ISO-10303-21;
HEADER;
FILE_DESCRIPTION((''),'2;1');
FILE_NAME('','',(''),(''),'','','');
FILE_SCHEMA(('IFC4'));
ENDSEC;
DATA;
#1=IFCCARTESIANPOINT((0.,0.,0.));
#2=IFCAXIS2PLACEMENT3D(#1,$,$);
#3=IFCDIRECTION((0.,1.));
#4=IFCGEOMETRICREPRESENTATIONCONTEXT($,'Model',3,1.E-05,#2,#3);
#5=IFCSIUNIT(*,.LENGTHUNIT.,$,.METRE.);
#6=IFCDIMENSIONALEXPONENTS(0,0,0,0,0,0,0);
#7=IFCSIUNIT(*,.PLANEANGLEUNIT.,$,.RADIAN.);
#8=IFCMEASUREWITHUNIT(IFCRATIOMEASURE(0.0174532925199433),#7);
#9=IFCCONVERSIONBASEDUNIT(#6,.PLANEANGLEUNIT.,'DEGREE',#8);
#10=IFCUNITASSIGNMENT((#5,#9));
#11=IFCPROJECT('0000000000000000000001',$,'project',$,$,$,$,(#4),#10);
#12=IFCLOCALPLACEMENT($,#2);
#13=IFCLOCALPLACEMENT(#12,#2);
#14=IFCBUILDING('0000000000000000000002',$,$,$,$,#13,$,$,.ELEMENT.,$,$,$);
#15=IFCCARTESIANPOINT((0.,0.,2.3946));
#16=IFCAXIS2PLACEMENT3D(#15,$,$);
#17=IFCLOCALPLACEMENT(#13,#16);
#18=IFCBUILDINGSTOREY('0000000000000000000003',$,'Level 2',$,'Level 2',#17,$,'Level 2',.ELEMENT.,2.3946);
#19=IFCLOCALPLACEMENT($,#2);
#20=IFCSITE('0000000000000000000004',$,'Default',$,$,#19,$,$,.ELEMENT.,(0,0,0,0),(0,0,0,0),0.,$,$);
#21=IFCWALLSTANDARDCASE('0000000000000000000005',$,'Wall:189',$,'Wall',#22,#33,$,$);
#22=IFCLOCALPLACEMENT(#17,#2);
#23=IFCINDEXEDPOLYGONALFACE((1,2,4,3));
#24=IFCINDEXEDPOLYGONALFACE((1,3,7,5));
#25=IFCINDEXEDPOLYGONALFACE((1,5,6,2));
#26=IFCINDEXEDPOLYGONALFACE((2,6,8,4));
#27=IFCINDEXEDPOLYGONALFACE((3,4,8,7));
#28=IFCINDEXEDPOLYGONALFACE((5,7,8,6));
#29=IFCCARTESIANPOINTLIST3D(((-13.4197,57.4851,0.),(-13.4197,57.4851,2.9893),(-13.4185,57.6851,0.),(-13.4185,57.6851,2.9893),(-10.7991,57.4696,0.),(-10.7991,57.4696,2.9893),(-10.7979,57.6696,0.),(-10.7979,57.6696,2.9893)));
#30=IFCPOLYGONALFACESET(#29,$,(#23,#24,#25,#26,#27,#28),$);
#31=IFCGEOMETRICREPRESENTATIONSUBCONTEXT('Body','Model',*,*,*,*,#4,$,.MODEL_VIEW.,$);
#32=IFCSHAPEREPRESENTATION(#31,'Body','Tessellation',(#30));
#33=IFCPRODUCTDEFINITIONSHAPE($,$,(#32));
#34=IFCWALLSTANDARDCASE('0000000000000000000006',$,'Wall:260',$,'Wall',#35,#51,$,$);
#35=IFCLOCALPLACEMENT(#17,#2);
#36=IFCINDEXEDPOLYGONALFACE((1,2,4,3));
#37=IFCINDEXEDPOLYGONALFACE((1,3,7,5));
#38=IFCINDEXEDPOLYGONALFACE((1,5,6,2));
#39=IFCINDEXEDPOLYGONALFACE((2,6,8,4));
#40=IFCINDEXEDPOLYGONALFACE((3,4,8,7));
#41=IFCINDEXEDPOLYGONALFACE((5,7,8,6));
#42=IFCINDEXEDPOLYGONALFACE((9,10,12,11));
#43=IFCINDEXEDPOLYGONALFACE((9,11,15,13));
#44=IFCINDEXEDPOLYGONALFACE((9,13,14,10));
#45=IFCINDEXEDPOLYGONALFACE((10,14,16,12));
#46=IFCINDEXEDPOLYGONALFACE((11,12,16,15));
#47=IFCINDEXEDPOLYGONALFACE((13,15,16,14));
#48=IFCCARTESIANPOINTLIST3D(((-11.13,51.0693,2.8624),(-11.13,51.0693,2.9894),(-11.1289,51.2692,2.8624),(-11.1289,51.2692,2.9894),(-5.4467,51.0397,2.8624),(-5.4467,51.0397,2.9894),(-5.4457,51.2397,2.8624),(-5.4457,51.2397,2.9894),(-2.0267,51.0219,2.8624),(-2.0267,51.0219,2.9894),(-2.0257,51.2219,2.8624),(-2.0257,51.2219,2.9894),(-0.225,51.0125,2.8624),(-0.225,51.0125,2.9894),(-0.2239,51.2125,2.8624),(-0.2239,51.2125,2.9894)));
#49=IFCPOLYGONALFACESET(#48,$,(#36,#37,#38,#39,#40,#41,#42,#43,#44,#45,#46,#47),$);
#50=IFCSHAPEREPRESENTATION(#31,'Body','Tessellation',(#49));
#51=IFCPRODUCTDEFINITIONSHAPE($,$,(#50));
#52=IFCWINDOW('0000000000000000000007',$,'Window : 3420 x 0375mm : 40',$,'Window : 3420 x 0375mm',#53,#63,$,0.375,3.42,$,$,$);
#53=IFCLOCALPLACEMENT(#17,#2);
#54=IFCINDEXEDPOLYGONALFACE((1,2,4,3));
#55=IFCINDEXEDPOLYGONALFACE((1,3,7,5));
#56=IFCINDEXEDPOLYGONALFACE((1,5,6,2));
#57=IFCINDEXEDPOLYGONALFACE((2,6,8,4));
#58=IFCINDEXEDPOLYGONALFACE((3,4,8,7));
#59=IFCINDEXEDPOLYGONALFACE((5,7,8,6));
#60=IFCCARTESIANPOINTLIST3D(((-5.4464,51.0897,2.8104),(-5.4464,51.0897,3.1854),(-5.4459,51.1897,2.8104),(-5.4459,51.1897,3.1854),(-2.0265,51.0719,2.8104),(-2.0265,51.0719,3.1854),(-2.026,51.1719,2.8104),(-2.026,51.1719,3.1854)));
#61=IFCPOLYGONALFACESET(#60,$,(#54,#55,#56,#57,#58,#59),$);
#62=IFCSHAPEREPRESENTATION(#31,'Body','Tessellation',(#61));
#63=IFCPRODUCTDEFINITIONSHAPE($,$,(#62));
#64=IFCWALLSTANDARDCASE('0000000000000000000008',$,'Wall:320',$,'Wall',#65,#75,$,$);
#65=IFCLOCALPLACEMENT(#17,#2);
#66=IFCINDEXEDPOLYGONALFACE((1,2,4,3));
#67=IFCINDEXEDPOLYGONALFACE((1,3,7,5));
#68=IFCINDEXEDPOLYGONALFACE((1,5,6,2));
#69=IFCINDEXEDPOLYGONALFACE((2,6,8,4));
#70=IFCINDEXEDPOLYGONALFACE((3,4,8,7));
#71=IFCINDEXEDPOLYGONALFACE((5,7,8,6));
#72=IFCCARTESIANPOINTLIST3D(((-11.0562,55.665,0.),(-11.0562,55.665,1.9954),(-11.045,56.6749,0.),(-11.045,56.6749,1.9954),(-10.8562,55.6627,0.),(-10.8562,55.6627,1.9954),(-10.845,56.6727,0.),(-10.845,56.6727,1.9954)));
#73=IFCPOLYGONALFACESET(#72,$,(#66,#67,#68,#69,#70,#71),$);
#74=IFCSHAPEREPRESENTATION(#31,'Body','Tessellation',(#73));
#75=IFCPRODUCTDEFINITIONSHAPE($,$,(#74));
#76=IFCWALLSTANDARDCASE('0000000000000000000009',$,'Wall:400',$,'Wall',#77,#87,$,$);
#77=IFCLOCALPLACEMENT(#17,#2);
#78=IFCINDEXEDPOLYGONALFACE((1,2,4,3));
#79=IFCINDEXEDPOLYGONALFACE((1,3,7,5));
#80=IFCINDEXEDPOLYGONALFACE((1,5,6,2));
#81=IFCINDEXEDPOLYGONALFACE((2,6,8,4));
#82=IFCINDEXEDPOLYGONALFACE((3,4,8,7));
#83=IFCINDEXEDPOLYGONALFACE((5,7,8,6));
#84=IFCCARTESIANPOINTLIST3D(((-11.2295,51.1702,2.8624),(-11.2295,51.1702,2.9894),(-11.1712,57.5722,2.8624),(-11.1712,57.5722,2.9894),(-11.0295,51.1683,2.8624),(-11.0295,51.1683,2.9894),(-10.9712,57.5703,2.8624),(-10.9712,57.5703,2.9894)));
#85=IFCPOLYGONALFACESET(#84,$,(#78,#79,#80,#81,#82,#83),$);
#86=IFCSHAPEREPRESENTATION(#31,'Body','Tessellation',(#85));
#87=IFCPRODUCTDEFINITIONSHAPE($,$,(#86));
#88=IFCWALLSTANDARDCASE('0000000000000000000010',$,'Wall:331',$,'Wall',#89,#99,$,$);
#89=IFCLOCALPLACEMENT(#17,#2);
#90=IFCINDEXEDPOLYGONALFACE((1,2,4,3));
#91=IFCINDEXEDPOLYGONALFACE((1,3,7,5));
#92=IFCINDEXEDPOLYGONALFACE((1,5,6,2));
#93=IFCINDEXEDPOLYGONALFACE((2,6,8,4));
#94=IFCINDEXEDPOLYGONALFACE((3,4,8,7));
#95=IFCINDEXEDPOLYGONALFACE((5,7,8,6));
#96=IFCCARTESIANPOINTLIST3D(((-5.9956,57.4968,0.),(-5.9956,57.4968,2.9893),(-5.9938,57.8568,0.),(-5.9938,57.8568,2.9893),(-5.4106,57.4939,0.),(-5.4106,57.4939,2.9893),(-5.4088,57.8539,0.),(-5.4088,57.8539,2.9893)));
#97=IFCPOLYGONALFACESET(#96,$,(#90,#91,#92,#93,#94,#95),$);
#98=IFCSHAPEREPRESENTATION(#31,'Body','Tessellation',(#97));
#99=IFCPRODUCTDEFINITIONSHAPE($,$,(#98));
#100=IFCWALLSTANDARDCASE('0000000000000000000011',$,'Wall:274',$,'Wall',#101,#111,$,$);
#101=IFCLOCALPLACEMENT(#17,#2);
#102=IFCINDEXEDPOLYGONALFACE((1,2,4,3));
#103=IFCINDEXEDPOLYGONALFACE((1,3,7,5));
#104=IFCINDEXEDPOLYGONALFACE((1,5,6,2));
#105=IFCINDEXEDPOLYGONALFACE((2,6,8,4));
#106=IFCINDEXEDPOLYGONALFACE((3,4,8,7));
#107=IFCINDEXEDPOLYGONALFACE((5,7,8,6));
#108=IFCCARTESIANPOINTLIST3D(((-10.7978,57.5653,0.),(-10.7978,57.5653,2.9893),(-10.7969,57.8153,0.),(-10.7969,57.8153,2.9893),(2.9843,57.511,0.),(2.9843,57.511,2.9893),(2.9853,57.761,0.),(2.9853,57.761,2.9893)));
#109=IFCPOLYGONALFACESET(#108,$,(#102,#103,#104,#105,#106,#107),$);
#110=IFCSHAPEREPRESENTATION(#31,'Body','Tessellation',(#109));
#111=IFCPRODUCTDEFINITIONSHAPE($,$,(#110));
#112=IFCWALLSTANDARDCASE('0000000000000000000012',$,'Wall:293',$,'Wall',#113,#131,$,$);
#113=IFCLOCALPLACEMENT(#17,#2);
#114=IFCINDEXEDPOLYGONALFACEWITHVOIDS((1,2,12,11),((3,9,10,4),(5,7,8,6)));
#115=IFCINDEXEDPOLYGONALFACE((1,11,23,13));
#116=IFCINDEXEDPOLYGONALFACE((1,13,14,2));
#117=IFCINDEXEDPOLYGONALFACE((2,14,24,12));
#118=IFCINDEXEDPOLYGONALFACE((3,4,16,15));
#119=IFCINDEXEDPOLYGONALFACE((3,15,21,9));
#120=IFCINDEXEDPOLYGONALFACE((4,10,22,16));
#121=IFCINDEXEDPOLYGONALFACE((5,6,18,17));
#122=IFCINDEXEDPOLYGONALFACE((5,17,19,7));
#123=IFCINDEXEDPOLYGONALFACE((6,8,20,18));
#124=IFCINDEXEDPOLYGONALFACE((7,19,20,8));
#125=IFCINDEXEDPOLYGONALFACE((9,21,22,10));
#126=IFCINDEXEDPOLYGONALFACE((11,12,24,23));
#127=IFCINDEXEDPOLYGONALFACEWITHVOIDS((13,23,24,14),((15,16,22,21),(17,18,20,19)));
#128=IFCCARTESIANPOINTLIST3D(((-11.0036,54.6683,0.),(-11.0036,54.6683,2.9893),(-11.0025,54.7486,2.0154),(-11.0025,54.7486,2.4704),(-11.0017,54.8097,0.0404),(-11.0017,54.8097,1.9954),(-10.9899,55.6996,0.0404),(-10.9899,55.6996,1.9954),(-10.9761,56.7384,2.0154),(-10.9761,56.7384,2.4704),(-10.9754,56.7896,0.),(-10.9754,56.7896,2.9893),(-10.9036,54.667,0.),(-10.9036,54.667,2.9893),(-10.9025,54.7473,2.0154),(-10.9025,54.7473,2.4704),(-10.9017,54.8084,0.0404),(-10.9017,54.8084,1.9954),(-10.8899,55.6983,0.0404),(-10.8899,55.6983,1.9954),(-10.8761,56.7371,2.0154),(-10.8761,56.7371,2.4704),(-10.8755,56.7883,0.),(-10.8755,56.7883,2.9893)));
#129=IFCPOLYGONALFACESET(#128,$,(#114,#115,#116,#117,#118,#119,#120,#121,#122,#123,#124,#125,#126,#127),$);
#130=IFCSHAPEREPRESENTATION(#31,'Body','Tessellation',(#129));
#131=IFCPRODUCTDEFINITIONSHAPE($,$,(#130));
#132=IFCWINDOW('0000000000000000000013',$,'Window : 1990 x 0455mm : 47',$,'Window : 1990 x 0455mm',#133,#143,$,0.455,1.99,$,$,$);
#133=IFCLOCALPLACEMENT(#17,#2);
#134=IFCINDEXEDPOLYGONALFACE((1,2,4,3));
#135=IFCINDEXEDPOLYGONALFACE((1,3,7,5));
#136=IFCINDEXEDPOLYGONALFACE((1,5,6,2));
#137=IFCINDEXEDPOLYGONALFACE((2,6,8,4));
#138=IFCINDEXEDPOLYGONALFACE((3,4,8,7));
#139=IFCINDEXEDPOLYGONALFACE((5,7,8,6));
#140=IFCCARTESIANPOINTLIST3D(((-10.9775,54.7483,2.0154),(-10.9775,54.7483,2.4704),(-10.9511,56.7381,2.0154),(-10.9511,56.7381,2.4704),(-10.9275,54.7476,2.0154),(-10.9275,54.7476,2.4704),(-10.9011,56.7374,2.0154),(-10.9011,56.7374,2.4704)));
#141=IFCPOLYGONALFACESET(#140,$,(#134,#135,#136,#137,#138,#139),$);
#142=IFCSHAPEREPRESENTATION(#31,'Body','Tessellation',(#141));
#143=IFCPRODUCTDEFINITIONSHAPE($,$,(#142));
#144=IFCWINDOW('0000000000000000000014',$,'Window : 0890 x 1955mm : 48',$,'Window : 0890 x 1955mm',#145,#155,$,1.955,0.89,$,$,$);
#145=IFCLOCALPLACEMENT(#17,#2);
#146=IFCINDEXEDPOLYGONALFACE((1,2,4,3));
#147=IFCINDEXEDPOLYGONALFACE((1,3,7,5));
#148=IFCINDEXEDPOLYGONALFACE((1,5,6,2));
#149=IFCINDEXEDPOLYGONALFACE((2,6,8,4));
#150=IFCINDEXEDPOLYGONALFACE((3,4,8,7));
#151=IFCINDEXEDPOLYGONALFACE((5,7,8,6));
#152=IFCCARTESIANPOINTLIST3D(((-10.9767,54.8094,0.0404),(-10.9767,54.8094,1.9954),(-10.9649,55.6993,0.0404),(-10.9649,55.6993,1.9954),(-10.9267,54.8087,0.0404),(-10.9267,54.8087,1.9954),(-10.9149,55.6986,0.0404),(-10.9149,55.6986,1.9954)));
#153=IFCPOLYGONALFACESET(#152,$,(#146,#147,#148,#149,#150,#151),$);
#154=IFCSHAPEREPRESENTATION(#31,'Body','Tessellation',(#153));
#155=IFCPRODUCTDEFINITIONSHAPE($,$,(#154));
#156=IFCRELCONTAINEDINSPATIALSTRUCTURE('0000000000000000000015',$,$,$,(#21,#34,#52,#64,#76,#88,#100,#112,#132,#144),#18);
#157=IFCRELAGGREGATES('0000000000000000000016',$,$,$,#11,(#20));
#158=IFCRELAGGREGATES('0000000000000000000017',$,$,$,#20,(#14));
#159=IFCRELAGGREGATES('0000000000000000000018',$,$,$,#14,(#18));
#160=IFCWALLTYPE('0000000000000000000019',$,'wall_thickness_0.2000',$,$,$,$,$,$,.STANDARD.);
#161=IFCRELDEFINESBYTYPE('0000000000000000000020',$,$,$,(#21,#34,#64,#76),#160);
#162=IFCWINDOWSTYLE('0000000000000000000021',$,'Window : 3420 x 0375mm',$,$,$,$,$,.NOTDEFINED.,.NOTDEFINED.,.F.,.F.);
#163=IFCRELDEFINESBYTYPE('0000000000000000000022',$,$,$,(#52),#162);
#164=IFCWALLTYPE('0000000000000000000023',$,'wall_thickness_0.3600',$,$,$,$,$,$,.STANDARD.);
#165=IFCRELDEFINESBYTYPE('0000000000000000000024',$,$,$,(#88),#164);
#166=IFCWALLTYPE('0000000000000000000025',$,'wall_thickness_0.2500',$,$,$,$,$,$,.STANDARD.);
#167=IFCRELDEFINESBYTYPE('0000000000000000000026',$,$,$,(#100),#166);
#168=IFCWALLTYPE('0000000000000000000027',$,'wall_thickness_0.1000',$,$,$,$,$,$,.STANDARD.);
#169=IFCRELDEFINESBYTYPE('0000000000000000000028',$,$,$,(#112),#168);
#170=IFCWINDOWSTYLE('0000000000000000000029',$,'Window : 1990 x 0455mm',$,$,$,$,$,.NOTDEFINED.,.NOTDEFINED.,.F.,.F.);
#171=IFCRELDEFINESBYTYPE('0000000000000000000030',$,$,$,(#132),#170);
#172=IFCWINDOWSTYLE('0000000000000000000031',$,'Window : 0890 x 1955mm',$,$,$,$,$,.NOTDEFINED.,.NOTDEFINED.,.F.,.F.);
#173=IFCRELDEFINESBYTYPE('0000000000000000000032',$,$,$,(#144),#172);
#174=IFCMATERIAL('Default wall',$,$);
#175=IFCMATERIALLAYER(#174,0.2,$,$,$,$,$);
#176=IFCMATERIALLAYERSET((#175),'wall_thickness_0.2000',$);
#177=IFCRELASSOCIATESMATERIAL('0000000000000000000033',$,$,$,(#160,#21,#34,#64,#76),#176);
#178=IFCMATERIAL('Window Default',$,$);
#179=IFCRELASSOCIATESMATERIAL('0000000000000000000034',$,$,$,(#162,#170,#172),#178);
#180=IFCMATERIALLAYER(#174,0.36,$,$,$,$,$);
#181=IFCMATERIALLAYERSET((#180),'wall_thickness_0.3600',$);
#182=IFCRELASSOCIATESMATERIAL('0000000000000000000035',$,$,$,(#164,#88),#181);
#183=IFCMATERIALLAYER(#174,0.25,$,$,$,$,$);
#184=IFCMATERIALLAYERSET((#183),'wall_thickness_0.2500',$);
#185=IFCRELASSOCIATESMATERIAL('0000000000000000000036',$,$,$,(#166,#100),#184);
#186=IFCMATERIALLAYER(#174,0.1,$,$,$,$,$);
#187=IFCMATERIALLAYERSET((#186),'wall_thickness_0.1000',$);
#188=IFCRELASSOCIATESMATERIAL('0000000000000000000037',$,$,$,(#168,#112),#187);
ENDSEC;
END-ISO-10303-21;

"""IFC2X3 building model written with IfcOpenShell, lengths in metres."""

from ifc_helpers import new_model, entity, si_unit, converted_unit, direction, frame, frame_2d, origin, origin_2d_with_axis, place, context, subcontext, project, spatial, polyline, rectangle, outline, extrude, source, transform, mapped, material, layer, layer_set, layer_usage, type_object, type_shapes, element, fill, save


model = new_model("IFC2X3")

# Units and contexts
model_context = context("Model", 3, precision=1e-05, world=origin(), true_north=direction((0.0, 1.0)))
body_context = subcontext(model_context, "Body", "Model", "MODEL_VIEW")
ifc_project = project(units=[si_unit("LENGTHUNIT", "METRE"), converted_unit("PLANEANGLEUNIT", "DEGREE", entity("IfcRatioMeasure", 0.0174532925199433), si_unit("PLANEANGLEUNIT", "RADIAN"), dimensions=[0, 0, 0, 0, 0, 0, 0])], contexts=[model_context])

# Site, building, storey
site_placement = place(None, origin())
site = spatial("IfcSite", under=ifc_project, at=site_placement, Name="Default", CompositionType="ELEMENT", RefLatitude=(0, 0, 0, 0), RefLongitude=(0, 0, 0, 0), RefElevation=0.0)
placement_1 = place(None, origin())
building_placement = place(placement_1, origin())
building = spatial("IfcBuilding", under=site, at=building_placement, CompositionType="ELEMENT")
storey_placement = place(building_placement, frame((0.0, 0.0, 2.3946)))
storey = spatial("IfcBuildingStorey", under=building, at=storey_placement, Name="Level 2", ObjectType="Level 2", LongName="Level 2", CompositionType="ELEMENT", Elevation=2.3946)

# Wall
ifc_material_1 = material(Name="Default wall")
ifc_layer_1 = layer(ifc_material_1, 0.2)
ifc_layer_set_1 = layer_set([ifc_layer_1], Name="wall_thickness_0.2000")
ifc_layer_usage_1 = layer_usage(ifc_layer_set_1, "AXIS2", "POSITIVE", -0.1)
wall_type_1 = type_object("IfcWallType", Name="wall_thickness_0.2000", PredefinedType="STANDARD", material=ifc_layer_set_1)
wall_1_placement = place(storey_placement, frame((-10.7985, 57.5696, 0.0), z_axis=(0.0, 0.0, 1.0), x_axis=(-0.999983, 0.005903, 0.0)))
element("IfcWallStandardCase", 1, at=wall_1_placement, inside=storey, type_object=wall_type_1, material=ifc_layer_usage_1, Name="Wall:189", ObjectType="Wall", context=body_context, shape_type="SweptSolid", body=[
    extrude(outline(polyline([(2.6206, -0.1), (2.6206, 0.1), (0.0, 0.1), (0.0, -0.1), (2.6206, -0.1)])), origin(), (0.0, 0.0, 1.0), 2.9893),
])

# Wall, opening, window
placement_2 = place(building_placement, frame((0.0, 0.0, 5.257)))
wall_2_placement = place(placement_2, frame((-11.1295, 51.1693, 0.0), z_axis=(0.0, 0.0, 1.0), x_axis=(0.999986, -0.005206, 0.0)))
wall_2 = element("IfcWallStandardCase", 2, at=wall_2_placement, inside=storey, type_object=wall_type_1, material=ifc_layer_usage_1, Name="Wall:260", ObjectType="Wall", context=body_context, shape_type="SweptSolid", body=[
    extrude(outline(polyline([(10.9052, -0.1), (10.9052, 0.1), (0.0, 0.1), (0.0, -0.1), (10.9052, -0.1)])), origin(), (0.0, 0.0, 1.0), 0.127),
])
opening_1_placement = place(wall_2_placement, frame((5.6834, -0.1, -0.052)))
opening_1 = element("IfcOpeningElement", 3, at=opening_1_placement, cuts=wall_2, ObjectType="Opening", context=body_context, shape_type="SweptSolid", body=[
    extrude(rectangle(XDim=3.42, YDim=0.375, at=frame_2d((0.1875, 1.71), x_axis=(0.0, 1.0))), frame((0.0, 0.0, 0.0), z_axis=(0.0, 1.0, 0.0), x_axis=(0.0, 0.0, 1.0)), (0.0, 0.0, 1.0), 0.2),
])
ifc_material_2 = material(Name="Window Default")
window_style_1 = type_object("IfcWindowStyle", Name="Window : 3420 x 0375mm", ConstructionType="NOTDEFINED", OperationType="NOTDEFINED", ParameterTakesPrecedence=False, Sizeable=False, material=ifc_material_2)
shared_shape_1 = source(origin(), body_context, "Body", "SweptSolid", [
    extrude(rectangle(XDim=0.1, YDim=3.42, at=origin_2d_with_axis()), frame((1.71, 0.1, 0.0), z_axis=(0.0, 0.0, 1.0), x_axis=(0.0, 1.0, 0.0)), (0.0, 0.0, 1.0), 0.375),
])
type_shapes(window_style_1, [shared_shape_1])
window_1_placement = place(opening_1_placement, origin())
window_1 = element("IfcWindow", 4, at=window_1_placement, inside=storey, type_object=window_style_1, Name="Window : 3420 x 0375mm : 40", ObjectType="Window : 3420 x 0375mm", OverallHeight=0.375, OverallWidth=3.42, context=body_context, shape_type="MappedRepresentation", body=[
    mapped(shared_shape_1, transform((0.0, 0.0, 0.0), scale=1.0)),
])
fill(opening_1, window_1)

# Walls
wall_3_placement = place(storey_placement, frame((-10.945, 56.6738, 0.0), z_axis=(0.0, 0.0, 1.0), x_axis=(-0.011159, -0.999938, 0.0)))
element("IfcWallStandardCase", 5, at=wall_3_placement, inside=storey, type_object=wall_type_1, material=ifc_layer_usage_1, Name="Wall:320", ObjectType="Wall", context=body_context, shape_type="SweptSolid", body=[
    extrude(outline(polyline([(1.01, -0.1), (1.01, 0.1), (0.0, 0.1), (0.0, -0.1), (1.01, -0.1)])), origin(), (0.0, 0.0, 1.0), 1.9954),
])
placement_3 = place(building_placement, frame((0.0, 0.0, 5.257)))
wall_4_placement = place(placement_3, frame((-11.0712, 57.5712, 0.0), z_axis=(0.0, 0.0, 1.0), x_axis=(-0.009099, -0.999959, 0.0)))
element("IfcWallStandardCase", 6, at=wall_4_placement, inside=storey, type_object=wall_type_1, material=ifc_layer_usage_1, Name="Wall:400", ObjectType="Wall", context=body_context, shape_type="SweptSolid", body=[
    extrude(outline(polyline([(6.4023, -0.1), (6.4023, 0.1), (0.0, 0.1), (0.0, -0.1), (6.4023, -0.1)])), origin(), (0.0, 0.0, 1.0), 0.127),
])
ifc_layer_2 = layer(ifc_material_1, 0.36)
ifc_layer_set_2 = layer_set([ifc_layer_2], Name="wall_thickness_0.3600")
ifc_layer_usage_2 = layer_usage(ifc_layer_set_2, "AXIS2", "POSITIVE", -0.18)
wall_type_2 = type_object("IfcWallType", Name="wall_thickness_0.3600", PredefinedType="STANDARD", material=ifc_layer_set_2)
wall_5_placement = place(storey_placement, frame((-5.9947, 57.6768, 0.0), z_axis=(0.0, 0.0, 1.0), x_axis=(0.999988, -0.004969, 0.0)))
element("IfcWallStandardCase", 7, at=wall_5_placement, inside=storey, type_object=wall_type_2, material=ifc_layer_usage_2, Name="Wall:331", ObjectType="Wall", context=body_context, shape_type="SweptSolid", body=[
    extrude(outline(polyline([(0.585, -0.18), (0.585, 0.18), (0.0, 0.18), (0.0, -0.18), (0.585, -0.18)])), origin(), (0.0, 0.0, 1.0), 2.9893),
])
ifc_layer_3 = layer(ifc_material_1, 0.25)
ifc_layer_set_3 = layer_set([ifc_layer_3], Name="wall_thickness_0.2500")
ifc_layer_usage_3 = layer_usage(ifc_layer_set_3, "AXIS2", "POSITIVE", -0.125)
wall_type_3 = type_object("IfcWallType", Name="wall_thickness_0.2500", PredefinedType="STANDARD", material=ifc_layer_set_3)
wall_6_placement = place(storey_placement, frame((-10.7973, 57.6903, 0.0), z_axis=(0.0, 0.0, 1.0), x_axis=(0.999992, -0.003941, 0.0)))
element("IfcWallStandardCase", 8, at=wall_6_placement, inside=storey, type_object=wall_type_3, material=ifc_layer_usage_3, Name="Wall:274", ObjectType="Wall", context=body_context, shape_type="SweptSolid", body=[
    extrude(outline(polyline([(13.7823, -0.125), (13.7823, 0.125), (0.0, 0.125), (0.0, -0.125), (13.7823, -0.125)])), origin(), (0.0, 0.0, 1.0), 2.9893),
])

# Wall, openings, windows
ifc_layer_4 = layer(ifc_material_1, 0.1)
ifc_layer_set_4 = layer_set([ifc_layer_4], Name="wall_thickness_0.1000")
ifc_layer_usage_4 = layer_usage(ifc_layer_set_4, "AXIS2", "POSITIVE", -0.05)
wall_type_4 = type_object("IfcWallType", Name="wall_thickness_0.1000", PredefinedType="STANDARD", material=ifc_layer_set_4)
wall_7_placement = place(storey_placement, frame((-10.9255, 56.789, 0.0), z_axis=(0.0, 0.0, 1.0), x_axis=(-0.013268, -0.999912, 0.0)))
wall_7 = element("IfcWallStandardCase", 9, at=wall_7_placement, inside=storey, type_object=wall_type_4, material=ifc_layer_usage_4, Name="Wall:293", ObjectType="Wall", context=body_context, shape_type="SweptSolid", body=[
    extrude(outline(polyline([(2.1215, -0.05), (2.1215, 0.05), (0.0, 0.05), (0.0, -0.05), (2.1215, -0.05)])), origin(), (0.0, 0.0, 1.0), 2.9893),
])
opening_2_placement = place(wall_7_placement, frame((0.0512, -0.05, 2.0154)))
opening_2 = element("IfcOpeningElement", 10, at=opening_2_placement, cuts=wall_7, ObjectType="Opening", context=body_context, shape_type="SweptSolid", body=[
    extrude(rectangle(XDim=1.99, YDim=0.455, at=frame_2d((0.2275, 0.995), x_axis=(0.0, 1.0))), frame((0.0, 0.0, 0.0), z_axis=(0.0, 1.0, 0.0), x_axis=(0.0, 0.0, 1.0)), (0.0, 0.0, 1.0), 0.1),
])
opening_3_placement = place(wall_7_placement, frame((1.0901, -0.05, 0.0404)))
opening_3 = element("IfcOpeningElement", 11, at=opening_3_placement, cuts=wall_7, ObjectType="Opening", context=body_context, shape_type="SweptSolid", body=[
    extrude(rectangle(XDim=0.89, YDim=1.955, at=frame_2d((0.9775, 0.445), x_axis=(0.0, 1.0))), frame((0.0, 0.0, 0.0), z_axis=(0.0, 1.0, 0.0), x_axis=(0.0, 0.0, 1.0)), (0.0, 0.0, 1.0), 0.1),
])
window_style_2 = type_object("IfcWindowStyle", Name="Window : 1990 x 0455mm", ConstructionType="NOTDEFINED", OperationType="NOTDEFINED", ParameterTakesPrecedence=False, Sizeable=False, material=ifc_material_2)
shared_shape_2 = source(origin(), body_context, "Body", "SweptSolid", [
    extrude(rectangle(XDim=0.05, YDim=1.99, at=origin_2d_with_axis()), frame((0.995, 0.05, 0.0), z_axis=(0.0, 0.0, 1.0), x_axis=(0.0, 1.0, 0.0)), (0.0, 0.0, 1.0), 0.455),
])
type_shapes(window_style_2, [shared_shape_2])
window_2_placement = place(opening_2_placement, origin())
window_2 = element("IfcWindow", 12, at=window_2_placement, inside=storey, type_object=window_style_2, Name="Window : 1990 x 0455mm : 47", ObjectType="Window : 1990 x 0455mm", OverallHeight=0.455, OverallWidth=1.99, context=body_context, shape_type="MappedRepresentation", body=[
    mapped(shared_shape_2, transform((0.0, 0.0, 0.0), scale=1.0)),
])
fill(opening_2, window_2)
window_style_3 = type_object("IfcWindowStyle", Name="Window : 0890 x 1955mm", ConstructionType="NOTDEFINED", OperationType="NOTDEFINED", ParameterTakesPrecedence=False, Sizeable=False, material=ifc_material_2)
shared_shape_3 = source(origin(), body_context, "Body", "SweptSolid", [
    extrude(rectangle(XDim=0.05, YDim=0.89, at=origin_2d_with_axis()), frame((0.445, 0.05, 0.0), z_axis=(0.0, 0.0, 1.0), x_axis=(0.0, 1.0, 0.0)), (0.0, 0.0, 1.0), 1.955),
])
type_shapes(window_style_3, [shared_shape_3])
window_3_placement = place(opening_3_placement, origin())
window_3 = element("IfcWindow", 13, at=window_3_placement, inside=storey, type_object=window_style_3, Name="Window : 0890 x 1955mm : 48", ObjectType="Window : 0890 x 1955mm", OverallHeight=1.955, OverallWidth=0.89, context=body_context, shape_type="MappedRepresentation", body=[
    mapped(shared_shape_3, transform((0.0, 0.0, 0.0), scale=1.0)),
])
fill(opening_3, window_3)

save(model, "model.ifc")
